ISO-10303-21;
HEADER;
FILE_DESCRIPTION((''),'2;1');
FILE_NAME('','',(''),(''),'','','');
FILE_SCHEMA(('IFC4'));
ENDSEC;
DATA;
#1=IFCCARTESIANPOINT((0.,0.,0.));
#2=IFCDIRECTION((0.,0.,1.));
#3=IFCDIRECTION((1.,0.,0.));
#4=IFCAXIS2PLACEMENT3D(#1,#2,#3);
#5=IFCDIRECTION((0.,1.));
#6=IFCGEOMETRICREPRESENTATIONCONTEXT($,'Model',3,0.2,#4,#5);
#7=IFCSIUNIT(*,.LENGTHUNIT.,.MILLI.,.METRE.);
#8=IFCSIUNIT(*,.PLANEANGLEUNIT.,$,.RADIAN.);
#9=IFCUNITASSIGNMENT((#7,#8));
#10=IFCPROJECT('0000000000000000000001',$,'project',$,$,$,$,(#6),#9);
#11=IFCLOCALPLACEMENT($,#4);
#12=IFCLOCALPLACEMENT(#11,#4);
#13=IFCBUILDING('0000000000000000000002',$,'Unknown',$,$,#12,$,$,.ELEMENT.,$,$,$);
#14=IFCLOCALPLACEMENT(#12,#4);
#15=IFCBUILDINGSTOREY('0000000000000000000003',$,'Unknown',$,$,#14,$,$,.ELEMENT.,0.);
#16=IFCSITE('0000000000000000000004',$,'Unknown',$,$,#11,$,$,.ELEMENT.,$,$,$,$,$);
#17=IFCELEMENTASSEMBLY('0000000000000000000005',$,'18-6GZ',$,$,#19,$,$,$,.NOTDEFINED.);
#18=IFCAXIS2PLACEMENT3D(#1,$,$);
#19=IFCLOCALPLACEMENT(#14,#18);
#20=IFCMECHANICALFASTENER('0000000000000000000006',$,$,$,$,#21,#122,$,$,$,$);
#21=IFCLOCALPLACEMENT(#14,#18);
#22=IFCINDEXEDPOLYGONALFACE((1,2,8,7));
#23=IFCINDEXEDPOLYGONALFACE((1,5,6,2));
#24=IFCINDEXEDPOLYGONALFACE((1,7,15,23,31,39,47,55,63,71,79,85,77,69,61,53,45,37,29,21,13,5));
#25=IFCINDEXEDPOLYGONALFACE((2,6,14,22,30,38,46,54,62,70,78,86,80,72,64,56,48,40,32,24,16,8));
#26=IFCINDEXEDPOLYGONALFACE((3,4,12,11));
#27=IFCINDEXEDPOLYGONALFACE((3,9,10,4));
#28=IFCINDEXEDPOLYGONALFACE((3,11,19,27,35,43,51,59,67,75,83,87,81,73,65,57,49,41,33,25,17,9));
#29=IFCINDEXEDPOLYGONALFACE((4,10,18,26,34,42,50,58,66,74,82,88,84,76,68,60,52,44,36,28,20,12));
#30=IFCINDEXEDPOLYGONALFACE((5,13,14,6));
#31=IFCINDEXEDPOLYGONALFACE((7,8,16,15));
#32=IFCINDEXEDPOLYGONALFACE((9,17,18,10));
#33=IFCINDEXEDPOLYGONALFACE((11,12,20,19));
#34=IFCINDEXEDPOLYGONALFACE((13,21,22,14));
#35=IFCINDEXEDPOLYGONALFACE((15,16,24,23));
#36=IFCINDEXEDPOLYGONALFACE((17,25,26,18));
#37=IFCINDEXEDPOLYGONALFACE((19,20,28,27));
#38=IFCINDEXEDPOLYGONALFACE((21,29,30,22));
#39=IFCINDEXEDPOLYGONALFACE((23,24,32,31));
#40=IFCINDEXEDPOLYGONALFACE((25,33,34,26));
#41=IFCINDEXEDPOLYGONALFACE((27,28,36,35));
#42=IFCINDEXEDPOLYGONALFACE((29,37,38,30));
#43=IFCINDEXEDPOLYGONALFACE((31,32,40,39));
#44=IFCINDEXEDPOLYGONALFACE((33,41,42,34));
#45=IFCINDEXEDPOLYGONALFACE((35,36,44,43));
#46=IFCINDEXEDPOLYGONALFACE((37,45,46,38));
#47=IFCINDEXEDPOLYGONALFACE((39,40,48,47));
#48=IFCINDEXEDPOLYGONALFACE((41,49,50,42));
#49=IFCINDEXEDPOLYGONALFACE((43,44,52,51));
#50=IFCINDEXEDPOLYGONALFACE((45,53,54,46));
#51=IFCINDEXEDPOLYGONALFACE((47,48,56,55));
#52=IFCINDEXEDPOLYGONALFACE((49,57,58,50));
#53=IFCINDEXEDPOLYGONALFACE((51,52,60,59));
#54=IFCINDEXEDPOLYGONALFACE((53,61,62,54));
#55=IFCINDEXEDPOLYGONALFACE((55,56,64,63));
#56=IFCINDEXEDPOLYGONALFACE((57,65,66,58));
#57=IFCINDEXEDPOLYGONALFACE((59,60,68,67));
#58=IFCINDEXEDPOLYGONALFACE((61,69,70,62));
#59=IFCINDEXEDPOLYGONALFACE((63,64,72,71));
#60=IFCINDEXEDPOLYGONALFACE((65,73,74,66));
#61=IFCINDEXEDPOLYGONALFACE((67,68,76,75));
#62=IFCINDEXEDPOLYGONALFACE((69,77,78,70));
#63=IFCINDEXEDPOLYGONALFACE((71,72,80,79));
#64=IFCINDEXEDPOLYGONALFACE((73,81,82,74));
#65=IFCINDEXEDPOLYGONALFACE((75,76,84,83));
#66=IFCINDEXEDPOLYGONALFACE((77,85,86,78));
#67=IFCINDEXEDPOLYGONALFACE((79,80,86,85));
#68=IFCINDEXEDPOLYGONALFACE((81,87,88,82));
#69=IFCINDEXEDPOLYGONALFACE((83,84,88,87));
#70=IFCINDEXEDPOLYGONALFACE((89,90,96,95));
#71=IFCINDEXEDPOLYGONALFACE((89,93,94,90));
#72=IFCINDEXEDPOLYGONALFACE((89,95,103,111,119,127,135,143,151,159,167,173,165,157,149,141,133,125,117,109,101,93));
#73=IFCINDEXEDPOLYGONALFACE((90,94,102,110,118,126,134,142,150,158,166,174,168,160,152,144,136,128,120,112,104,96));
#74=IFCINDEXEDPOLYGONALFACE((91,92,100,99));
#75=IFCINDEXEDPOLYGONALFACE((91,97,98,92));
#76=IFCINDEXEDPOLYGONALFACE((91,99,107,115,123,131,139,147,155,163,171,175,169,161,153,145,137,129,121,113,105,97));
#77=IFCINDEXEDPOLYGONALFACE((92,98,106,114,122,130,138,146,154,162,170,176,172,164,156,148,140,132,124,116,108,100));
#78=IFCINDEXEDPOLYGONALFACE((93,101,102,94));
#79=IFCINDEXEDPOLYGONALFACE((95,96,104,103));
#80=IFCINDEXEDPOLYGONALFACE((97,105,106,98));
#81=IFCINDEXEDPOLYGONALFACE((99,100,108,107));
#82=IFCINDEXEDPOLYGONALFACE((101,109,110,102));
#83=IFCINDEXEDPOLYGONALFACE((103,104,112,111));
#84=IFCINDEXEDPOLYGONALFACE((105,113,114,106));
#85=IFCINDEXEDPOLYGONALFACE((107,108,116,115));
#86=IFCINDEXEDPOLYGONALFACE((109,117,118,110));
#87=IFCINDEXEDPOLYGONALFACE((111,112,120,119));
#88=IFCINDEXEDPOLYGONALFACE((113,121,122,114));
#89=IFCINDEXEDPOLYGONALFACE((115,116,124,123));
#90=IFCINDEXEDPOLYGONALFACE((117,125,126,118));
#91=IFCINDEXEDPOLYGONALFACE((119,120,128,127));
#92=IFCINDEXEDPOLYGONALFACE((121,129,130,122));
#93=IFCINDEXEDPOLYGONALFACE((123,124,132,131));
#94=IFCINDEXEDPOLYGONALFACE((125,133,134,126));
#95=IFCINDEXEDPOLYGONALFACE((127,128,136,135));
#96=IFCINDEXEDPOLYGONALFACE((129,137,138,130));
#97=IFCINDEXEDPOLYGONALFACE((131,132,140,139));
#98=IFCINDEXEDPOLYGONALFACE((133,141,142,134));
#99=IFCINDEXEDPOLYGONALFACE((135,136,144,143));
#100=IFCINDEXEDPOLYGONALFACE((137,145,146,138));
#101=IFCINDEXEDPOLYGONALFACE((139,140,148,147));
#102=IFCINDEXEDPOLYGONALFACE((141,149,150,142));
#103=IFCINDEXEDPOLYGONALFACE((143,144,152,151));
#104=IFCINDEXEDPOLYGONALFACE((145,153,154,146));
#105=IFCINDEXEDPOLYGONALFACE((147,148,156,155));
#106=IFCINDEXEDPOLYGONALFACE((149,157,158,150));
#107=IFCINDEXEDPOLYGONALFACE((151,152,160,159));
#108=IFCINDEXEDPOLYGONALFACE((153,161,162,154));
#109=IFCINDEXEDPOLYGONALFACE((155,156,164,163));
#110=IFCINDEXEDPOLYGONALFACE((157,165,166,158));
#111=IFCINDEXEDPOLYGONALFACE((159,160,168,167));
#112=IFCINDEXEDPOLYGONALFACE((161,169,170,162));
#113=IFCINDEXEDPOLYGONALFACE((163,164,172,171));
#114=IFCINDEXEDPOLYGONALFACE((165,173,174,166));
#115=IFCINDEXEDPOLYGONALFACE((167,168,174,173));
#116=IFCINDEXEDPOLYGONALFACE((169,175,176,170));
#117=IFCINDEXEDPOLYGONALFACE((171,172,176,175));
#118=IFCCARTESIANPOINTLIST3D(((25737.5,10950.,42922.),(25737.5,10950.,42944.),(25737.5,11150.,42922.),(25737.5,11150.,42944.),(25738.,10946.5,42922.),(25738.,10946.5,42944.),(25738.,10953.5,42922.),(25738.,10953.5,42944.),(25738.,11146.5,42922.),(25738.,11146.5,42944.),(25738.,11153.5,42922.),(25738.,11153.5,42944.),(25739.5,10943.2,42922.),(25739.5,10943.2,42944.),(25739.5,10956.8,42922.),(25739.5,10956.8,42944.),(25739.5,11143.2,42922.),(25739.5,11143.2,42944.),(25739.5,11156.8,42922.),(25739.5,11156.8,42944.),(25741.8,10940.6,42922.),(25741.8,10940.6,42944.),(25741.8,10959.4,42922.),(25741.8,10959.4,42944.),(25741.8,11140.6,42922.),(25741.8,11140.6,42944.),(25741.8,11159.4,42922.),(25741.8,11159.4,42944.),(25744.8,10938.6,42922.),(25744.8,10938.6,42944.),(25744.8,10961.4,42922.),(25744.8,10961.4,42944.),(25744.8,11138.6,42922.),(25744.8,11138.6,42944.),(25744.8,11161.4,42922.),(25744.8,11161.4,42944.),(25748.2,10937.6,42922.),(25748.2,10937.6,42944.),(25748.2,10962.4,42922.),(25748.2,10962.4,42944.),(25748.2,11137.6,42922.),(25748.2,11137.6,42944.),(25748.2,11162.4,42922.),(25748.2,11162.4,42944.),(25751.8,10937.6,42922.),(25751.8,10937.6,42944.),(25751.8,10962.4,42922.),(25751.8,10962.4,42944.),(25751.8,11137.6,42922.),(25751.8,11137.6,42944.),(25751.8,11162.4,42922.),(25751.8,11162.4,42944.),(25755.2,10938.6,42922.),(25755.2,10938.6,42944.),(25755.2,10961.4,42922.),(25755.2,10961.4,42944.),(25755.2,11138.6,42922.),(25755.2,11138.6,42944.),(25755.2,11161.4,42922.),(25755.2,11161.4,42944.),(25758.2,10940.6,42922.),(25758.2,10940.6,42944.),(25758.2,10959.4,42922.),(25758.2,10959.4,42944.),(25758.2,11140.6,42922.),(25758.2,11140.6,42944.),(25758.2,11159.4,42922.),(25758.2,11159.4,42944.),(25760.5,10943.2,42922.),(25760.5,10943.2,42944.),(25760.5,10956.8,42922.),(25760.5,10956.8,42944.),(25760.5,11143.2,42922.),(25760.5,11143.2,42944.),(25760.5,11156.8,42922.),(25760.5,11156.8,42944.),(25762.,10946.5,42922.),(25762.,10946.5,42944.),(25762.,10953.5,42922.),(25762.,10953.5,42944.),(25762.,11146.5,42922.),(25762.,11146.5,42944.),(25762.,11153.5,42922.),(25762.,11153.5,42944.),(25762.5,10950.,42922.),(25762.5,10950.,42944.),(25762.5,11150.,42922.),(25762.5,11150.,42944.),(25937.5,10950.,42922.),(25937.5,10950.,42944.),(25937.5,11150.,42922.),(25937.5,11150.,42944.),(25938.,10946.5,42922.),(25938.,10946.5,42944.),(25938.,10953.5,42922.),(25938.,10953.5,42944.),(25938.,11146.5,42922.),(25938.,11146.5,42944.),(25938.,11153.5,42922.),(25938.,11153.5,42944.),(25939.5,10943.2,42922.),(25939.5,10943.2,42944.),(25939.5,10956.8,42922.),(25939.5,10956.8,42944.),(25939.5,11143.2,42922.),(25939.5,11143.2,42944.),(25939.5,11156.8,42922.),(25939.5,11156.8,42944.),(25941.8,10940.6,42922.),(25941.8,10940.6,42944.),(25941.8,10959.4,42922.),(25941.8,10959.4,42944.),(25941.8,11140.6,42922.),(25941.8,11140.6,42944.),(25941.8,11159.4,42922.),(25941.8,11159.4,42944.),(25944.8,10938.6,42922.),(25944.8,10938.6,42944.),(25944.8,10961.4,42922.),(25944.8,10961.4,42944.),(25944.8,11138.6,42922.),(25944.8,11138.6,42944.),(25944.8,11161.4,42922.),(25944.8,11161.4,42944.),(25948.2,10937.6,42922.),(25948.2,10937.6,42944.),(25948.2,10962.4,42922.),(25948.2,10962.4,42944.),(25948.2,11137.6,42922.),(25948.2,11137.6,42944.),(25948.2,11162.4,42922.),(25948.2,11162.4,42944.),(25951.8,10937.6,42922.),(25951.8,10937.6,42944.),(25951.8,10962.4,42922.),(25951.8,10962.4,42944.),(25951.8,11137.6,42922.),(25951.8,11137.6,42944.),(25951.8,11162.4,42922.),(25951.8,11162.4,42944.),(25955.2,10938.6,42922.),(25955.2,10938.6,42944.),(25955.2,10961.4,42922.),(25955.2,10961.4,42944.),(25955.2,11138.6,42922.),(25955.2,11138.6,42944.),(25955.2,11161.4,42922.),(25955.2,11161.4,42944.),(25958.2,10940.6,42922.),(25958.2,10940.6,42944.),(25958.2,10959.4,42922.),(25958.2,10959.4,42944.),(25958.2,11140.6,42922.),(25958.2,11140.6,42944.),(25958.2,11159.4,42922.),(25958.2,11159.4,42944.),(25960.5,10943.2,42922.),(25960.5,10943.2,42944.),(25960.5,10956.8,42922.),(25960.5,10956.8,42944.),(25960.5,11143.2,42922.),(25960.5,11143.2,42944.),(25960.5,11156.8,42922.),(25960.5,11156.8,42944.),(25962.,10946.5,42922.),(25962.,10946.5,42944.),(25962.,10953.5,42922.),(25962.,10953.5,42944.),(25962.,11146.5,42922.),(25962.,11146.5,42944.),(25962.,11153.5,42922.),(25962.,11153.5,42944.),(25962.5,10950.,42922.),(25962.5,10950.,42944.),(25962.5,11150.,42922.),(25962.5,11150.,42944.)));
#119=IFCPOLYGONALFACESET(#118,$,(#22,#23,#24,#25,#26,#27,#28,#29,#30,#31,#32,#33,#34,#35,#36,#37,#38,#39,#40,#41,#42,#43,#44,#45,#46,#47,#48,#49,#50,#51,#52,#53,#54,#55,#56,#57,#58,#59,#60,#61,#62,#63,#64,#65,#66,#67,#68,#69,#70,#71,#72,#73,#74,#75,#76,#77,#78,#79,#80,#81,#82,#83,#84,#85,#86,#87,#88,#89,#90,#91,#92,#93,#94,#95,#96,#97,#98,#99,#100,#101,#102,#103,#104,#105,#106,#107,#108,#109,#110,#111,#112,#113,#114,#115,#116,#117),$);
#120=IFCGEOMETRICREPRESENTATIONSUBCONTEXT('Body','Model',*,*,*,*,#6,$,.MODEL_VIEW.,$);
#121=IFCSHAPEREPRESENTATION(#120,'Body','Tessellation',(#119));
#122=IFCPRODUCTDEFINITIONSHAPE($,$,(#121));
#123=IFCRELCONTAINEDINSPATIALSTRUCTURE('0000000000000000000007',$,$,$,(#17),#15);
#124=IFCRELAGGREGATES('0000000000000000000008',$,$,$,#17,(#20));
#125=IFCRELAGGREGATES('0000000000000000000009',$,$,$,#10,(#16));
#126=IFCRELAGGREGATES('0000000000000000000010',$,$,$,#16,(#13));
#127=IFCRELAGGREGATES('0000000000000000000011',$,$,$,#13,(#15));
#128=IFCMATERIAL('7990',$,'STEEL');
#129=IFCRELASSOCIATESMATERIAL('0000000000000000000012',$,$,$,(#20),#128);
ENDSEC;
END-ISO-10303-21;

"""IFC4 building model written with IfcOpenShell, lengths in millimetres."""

from ifc_helpers import new_model, si_unit, direction, frame, origin_with_axes, place, context, subcontext, project, spatial, arc, indexed_curve, outline, extrude, source, transform, mapped, material, element, aggregate, save


model = new_model("IFC4")

# Units and contexts
model_context = context("Model", 3, precision=0.2, world=origin_with_axes(), true_north=direction((0.0, 1.0)))
body_context = subcontext(model_context, "Body", "Model", "MODEL_VIEW")
ifc_project = project(units=[si_unit("LENGTHUNIT", "METRE", prefix="MILLI"), si_unit("PLANEANGLEUNIT", "RADIAN")], contexts=[model_context])

# Site, building, storey
site_placement = place(None, origin_with_axes())
site = spatial("IfcSite", under=ifc_project, at=site_placement, Name="Unknown", CompositionType="ELEMENT")
building_placement = place(site_placement, origin_with_axes())
building = spatial("IfcBuilding", under=site, at=building_placement, Name="Unknown", CompositionType="ELEMENT")
storey_placement = place(building_placement, origin_with_axes())
storey = spatial("IfcBuildingStorey", under=building, at=storey_placement, Name="Unknown", CompositionType="ELEMENT", Elevation=0.0)

# Element assembly
assembly_1_placement = place(storey_placement, frame((25850.0, 11050.0, 35950.0), z_axis=(-1.0, 0.0, 0.0), x_axis=(0.0, 0.0, 1.0)))
assembly_1 = element("IfcElementAssembly", 1, at=assembly_1_placement, inside=storey, Name="18-6GZ", PredefinedType="NOTDEFINED")

# Mechanical fastener
ifc_material_1 = material(Name="7990", Category="STEEL")
placement_1 = place(assembly_1_placement, frame((6972.0, 0.0, 0.0), z_axis=(-1.0, 0.0, 0.0), x_axis=(0.0, 1.0, 0.0)))
shared_shape_1 = source(origin_with_axes(), body_context, "Body", "SweptSolid", [
    extrude(outline(indexed_curve([(12.5, 0.0), (0.0, 12.5), (-12.5, 0.0), (0.0, -12.5)], segments=[arc(1, 2, 3), arc(3, 4, 1)])), frame((0.0, 0.0, 0.0), z_axis=(0.0, 0.0, -1.0), x_axis=(0.0, 1.0, 0.0)), (0.0, 0.0, 1.0), 22.0),
])
mechanical_fastener_1 = element("IfcMechanicalFastener", 2, at=placement_1, material=ifc_material_1, context=body_context, shape_type="MappedRepresentation", body=[
    mapped(shared_shape_1, transform((-100.0, -100.0, 0.0))),
    mapped(shared_shape_1, transform((100.0, -100.0, 0.0))),
    mapped(shared_shape_1, transform((-100.0, 100.0, 0.0))),
    mapped(shared_shape_1, transform((100.0, 100.0, 0.0))),
])
aggregate(assembly_1, [mechanical_fastener_1])

save(model, "model.ifc")
